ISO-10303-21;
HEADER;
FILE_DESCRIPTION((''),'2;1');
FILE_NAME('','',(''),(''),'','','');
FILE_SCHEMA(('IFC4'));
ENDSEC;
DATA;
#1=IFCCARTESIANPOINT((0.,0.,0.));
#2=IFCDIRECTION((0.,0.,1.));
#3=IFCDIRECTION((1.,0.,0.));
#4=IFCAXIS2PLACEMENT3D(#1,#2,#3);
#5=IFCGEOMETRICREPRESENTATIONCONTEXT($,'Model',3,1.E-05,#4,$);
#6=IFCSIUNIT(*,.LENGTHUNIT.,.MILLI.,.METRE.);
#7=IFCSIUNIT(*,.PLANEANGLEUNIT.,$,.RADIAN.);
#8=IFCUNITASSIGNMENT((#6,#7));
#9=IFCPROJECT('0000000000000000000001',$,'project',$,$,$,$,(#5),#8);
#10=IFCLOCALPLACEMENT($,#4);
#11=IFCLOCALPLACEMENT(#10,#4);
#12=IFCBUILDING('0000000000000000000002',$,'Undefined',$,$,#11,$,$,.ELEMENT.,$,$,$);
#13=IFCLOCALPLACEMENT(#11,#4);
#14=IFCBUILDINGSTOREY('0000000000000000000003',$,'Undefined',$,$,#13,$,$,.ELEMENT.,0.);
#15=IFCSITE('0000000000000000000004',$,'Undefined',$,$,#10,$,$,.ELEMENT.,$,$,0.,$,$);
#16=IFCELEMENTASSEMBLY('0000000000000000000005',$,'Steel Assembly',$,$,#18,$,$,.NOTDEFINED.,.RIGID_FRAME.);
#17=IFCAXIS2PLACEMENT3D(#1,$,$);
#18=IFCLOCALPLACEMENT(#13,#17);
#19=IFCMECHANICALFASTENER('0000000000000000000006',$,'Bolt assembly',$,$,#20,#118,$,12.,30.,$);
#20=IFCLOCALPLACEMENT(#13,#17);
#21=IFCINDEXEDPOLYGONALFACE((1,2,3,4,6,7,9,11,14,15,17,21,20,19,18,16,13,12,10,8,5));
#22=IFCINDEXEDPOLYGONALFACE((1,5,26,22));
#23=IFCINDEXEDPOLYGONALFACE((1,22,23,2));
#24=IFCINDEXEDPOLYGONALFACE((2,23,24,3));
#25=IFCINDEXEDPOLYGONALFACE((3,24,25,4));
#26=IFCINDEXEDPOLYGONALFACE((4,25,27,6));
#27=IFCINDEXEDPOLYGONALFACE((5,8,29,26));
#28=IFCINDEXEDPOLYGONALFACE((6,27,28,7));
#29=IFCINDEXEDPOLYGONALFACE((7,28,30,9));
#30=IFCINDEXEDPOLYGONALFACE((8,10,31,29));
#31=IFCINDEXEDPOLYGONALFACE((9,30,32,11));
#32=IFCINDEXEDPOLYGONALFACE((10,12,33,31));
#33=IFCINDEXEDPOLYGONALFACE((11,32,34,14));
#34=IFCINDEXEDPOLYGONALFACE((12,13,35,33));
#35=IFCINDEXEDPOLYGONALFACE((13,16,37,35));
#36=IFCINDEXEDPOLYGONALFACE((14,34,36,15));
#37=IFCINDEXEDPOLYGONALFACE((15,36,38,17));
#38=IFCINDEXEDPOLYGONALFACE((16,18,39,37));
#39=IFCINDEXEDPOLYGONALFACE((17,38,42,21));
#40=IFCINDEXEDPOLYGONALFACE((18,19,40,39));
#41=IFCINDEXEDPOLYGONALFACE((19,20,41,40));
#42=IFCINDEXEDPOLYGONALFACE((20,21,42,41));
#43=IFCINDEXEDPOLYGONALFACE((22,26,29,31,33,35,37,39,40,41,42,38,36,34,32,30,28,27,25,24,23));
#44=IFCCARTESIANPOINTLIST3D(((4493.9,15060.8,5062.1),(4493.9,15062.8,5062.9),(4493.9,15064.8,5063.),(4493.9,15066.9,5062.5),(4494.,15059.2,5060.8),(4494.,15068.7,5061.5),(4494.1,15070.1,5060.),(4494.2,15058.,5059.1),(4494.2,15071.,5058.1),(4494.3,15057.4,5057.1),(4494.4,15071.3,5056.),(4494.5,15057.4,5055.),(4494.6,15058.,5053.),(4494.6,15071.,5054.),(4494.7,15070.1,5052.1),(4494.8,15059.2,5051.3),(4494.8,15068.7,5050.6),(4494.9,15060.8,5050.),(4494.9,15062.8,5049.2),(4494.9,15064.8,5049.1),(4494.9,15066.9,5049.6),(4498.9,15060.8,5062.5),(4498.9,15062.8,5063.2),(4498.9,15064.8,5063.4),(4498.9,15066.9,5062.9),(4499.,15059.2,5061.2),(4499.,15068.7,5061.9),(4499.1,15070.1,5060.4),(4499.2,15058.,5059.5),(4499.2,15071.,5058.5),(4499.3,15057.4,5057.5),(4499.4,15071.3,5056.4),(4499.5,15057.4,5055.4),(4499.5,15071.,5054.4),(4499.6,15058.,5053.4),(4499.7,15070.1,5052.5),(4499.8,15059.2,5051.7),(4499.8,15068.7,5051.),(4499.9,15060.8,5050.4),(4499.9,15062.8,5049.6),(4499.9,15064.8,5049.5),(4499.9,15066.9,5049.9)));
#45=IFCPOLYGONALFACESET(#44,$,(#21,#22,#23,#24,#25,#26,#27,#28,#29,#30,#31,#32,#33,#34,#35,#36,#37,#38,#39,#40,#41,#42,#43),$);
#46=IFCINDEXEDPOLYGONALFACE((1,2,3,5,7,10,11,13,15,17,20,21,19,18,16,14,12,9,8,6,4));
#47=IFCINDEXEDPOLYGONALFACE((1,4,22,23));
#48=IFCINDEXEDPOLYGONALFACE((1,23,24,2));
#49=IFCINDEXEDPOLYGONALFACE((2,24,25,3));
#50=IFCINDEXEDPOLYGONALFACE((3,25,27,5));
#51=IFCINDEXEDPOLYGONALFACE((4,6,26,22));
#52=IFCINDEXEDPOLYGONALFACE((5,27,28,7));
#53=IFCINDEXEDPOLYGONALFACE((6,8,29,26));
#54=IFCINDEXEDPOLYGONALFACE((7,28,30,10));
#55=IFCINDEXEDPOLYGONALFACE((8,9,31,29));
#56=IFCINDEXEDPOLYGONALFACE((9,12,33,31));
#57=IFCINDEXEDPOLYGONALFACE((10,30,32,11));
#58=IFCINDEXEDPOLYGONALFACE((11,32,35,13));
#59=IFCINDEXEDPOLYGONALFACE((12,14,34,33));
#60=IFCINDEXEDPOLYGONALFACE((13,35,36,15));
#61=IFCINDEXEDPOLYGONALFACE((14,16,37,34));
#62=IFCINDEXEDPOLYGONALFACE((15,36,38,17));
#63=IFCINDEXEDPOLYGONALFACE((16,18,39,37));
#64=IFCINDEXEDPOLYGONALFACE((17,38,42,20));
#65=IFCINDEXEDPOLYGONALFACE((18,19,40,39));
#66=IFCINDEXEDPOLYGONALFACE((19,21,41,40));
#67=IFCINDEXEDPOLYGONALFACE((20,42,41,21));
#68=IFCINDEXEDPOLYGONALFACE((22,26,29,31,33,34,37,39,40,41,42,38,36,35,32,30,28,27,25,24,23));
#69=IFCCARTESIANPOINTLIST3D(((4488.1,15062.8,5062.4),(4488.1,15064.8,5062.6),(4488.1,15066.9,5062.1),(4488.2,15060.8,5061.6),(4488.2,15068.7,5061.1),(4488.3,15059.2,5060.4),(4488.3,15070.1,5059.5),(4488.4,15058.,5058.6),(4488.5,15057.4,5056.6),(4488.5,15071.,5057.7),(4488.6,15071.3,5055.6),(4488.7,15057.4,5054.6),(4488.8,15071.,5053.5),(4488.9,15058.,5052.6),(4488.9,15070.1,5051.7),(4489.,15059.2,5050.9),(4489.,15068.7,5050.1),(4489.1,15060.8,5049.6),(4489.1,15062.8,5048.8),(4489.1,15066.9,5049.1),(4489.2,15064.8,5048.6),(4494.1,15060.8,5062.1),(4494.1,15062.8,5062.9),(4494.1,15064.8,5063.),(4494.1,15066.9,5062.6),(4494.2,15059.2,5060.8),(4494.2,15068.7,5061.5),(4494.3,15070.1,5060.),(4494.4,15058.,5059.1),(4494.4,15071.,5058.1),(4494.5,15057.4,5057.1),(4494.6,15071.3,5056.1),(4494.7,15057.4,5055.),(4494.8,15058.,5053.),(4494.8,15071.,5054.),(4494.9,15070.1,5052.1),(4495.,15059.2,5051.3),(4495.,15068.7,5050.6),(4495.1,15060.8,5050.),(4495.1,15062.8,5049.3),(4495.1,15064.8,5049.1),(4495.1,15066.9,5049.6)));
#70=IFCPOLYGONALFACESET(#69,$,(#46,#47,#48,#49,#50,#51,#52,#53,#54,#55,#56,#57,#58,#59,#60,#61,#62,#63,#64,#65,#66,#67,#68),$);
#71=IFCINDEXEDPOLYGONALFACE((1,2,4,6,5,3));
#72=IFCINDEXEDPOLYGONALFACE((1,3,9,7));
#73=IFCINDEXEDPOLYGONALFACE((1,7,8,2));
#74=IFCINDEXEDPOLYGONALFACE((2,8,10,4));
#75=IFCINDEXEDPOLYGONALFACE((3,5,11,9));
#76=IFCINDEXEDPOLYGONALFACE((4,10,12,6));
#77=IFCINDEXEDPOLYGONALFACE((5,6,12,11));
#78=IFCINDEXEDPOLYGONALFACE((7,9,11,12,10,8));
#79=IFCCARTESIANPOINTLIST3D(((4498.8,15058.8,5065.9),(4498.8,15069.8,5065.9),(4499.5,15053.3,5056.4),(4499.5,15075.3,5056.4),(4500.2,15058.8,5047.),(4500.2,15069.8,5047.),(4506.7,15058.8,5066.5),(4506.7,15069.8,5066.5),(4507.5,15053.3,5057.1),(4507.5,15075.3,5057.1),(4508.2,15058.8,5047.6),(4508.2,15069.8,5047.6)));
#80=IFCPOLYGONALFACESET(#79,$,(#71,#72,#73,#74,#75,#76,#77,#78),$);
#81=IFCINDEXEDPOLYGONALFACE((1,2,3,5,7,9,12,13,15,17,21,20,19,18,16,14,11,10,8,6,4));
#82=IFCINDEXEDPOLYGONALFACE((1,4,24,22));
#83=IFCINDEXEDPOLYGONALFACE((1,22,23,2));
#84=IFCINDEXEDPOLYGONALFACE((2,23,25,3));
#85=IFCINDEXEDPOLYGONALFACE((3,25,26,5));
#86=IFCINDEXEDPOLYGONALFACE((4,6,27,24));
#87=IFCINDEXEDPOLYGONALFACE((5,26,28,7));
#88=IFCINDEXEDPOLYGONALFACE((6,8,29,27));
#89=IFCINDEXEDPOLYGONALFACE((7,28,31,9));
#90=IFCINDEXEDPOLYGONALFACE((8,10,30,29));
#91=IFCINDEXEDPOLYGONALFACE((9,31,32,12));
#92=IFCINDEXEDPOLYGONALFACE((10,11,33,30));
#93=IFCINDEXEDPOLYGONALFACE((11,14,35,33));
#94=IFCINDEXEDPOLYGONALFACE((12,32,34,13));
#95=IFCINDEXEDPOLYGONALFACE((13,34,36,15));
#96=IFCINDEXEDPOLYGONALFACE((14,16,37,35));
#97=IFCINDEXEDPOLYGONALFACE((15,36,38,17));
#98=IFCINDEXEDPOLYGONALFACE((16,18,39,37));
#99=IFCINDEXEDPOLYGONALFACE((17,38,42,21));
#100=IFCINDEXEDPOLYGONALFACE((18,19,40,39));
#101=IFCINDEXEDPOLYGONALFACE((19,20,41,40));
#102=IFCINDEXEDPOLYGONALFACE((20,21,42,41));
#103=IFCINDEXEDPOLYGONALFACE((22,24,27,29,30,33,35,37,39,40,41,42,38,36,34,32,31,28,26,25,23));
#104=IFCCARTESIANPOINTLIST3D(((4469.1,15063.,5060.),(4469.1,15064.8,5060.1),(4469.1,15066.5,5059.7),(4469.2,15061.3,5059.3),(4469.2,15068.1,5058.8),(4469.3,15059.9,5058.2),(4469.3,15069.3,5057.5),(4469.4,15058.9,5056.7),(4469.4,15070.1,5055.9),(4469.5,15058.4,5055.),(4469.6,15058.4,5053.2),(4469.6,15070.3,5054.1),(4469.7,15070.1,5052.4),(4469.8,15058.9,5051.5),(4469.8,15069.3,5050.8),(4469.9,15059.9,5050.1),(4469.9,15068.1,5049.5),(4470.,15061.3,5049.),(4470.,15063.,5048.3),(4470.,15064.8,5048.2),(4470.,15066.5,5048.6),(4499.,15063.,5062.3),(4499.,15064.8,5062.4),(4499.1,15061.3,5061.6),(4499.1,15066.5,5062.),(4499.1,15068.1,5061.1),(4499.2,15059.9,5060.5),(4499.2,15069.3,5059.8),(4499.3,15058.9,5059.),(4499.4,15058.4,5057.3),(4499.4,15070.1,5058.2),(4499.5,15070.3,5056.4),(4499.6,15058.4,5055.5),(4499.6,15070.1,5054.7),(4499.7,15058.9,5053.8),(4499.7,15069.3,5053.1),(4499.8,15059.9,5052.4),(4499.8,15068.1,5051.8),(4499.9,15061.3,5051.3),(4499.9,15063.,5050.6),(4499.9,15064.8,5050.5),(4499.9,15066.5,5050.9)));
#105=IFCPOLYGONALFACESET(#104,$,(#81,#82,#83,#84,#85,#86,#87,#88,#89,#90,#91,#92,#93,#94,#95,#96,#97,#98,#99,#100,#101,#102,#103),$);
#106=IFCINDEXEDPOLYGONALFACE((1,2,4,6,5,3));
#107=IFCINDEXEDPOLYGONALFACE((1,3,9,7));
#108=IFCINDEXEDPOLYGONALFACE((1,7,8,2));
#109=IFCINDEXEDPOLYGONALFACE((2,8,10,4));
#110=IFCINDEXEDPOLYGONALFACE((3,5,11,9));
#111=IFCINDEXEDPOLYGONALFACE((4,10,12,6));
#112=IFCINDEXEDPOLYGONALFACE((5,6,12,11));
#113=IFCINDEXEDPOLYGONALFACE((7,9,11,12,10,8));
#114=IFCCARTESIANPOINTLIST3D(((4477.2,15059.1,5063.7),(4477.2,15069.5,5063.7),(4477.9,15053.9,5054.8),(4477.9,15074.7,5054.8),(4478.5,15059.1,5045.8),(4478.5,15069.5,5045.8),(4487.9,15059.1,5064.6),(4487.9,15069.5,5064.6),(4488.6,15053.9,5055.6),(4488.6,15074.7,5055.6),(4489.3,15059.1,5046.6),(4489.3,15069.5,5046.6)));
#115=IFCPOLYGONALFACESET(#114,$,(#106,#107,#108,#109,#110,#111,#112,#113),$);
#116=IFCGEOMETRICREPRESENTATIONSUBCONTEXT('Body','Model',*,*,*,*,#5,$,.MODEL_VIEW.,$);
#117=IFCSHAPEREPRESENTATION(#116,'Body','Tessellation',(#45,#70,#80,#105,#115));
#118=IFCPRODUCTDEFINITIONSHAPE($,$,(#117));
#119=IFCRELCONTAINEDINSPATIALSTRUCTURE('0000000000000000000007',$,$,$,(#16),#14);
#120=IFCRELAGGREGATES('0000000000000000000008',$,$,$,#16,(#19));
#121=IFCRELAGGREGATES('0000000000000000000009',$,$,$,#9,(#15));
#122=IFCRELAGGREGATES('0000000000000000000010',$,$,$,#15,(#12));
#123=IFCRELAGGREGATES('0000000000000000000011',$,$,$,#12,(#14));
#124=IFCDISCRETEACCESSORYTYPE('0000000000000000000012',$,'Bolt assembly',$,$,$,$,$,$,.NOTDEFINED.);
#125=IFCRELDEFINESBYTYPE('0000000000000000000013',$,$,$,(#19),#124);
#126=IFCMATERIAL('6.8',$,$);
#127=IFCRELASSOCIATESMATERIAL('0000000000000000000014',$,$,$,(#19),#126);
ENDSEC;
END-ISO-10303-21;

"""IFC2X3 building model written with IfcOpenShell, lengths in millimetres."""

from ifc_helpers import new_model, si_unit, frame, origin_with_axes, origin_2d_with_axis, place, context, subcontext, project, spatial, polyline, circle, outline, extrude, source, transform, mapped, material, type_object, element, aggregate, save


model = new_model("IFC2X3")

# Units and contexts
model_context = context("Model", 3, precision=1e-05, world=origin_with_axes())
body_context = subcontext(model_context, "Body", "Model", "MODEL_VIEW")
ifc_project = project(units=[si_unit("LENGTHUNIT", "METRE", prefix="MILLI"), si_unit("PLANEANGLEUNIT", "RADIAN")], contexts=[model_context])

# Site, building, storey
site_placement = place(None, origin_with_axes())
site = spatial("IfcSite", under=ifc_project, at=site_placement, Name="Undefined", CompositionType="ELEMENT", RefElevation=0.0)
building_placement = place(site_placement, origin_with_axes())
building = spatial("IfcBuilding", under=site, at=building_placement, Name="Undefined", CompositionType="ELEMENT")
storey_placement = place(building_placement, origin_with_axes())
storey = spatial("IfcBuildingStorey", under=building, at=storey_placement, Name="Undefined", CompositionType="ELEMENT", Elevation=0.0)

# Element assembly
assembly_1_placement = place(storey_placement, origin_with_axes())
assembly_1 = element("IfcElementAssembly", 1, at=assembly_1_placement, inside=storey, Name="Steel Assembly", AssemblyPlace="NOTDEFINED", PredefinedType="RIGID_FRAME")

# Shared definitions
ifc_material_1 = material(Name="6.8")
discrete_accessory_type_1 = type_object("IfcDiscreteAccessoryType", Name="Bolt assembly")

# Mechanical fastener
shared_shape_1 = source(origin_with_axes(), body_context, "Body", "SweptSolid", [
    extrude(circle(Radius=7.0, at=origin_2d_with_axis()), frame((0.0, -4.9, 0.0), z_axis=(0.0, 1.0, 0.0), x_axis=(1.0, 0.0, 0.0)), (0.0, 0.0, 1.0), 5.0),
    extrude(circle(Radius=7.0, at=origin_2d_with_axis()), frame((0.0, -0.1, 0.0), z_axis=(0.0, 1.0, 0.0), x_axis=(1.0, 0.0, 0.0)), (0.0, 0.0, 1.0), 6.0),
    extrude(outline(polyline([(11.0, 0.0), (5.5, 9.5), (-5.5, 9.5), (-11.0, 0.0), (-5.5, -9.5), (5.5, -9.5), (11.0, 0.0)])), frame((0.0, -13.0, 0.0), z_axis=(0.0, 1.0, 0.0), x_axis=(1.0, 0.0, 0.0)), (0.0, 0.0, 1.0), 8.0),
    extrude(circle(Radius=6.0, at=origin_2d_with_axis()), frame((0.0, -5.0, 0.0), z_axis=(0.0, 1.0, 0.0), x_axis=(1.0, 0.0, 0.0)), (0.0, 0.0, 1.0), 30.0),
    extrude(outline(polyline([(10.4, 0.0), (5.2, 9.0), (-5.2, 9.0), (-10.4, 0.0), (-5.2, -9.0), (5.2, -9.0), (10.4, 0.0)])), frame((0.0, 5.9, 0.0), z_axis=(0.0, 1.0, 0.0), x_axis=(1.0, 0.0, 0.0)), (0.0, 0.0, 1.0), 10.8),
])
mechanical_fastener_1_placement = place(assembly_1_placement, frame((4494.5, 15064.3, 5056.1), z_axis=(-0.076696, 0.0, 0.997054), x_axis=(0.0, 1.0, 0.0)))
mechanical_fastener_1 = element("IfcMechanicalFastener", 2, at=mechanical_fastener_1_placement, type_object=discrete_accessory_type_1, material=ifc_material_1, Name="Bolt assembly", NominalDiameter=12.0, NominalLength=30.0, context=body_context, shape_type="MappedRepresentation", body=[
    mapped(shared_shape_1, transform((0.0, 0.0, 0.0))),
])
aggregate(assembly_1, [mechanical_fastener_1])

save(model, "model.ifc")
